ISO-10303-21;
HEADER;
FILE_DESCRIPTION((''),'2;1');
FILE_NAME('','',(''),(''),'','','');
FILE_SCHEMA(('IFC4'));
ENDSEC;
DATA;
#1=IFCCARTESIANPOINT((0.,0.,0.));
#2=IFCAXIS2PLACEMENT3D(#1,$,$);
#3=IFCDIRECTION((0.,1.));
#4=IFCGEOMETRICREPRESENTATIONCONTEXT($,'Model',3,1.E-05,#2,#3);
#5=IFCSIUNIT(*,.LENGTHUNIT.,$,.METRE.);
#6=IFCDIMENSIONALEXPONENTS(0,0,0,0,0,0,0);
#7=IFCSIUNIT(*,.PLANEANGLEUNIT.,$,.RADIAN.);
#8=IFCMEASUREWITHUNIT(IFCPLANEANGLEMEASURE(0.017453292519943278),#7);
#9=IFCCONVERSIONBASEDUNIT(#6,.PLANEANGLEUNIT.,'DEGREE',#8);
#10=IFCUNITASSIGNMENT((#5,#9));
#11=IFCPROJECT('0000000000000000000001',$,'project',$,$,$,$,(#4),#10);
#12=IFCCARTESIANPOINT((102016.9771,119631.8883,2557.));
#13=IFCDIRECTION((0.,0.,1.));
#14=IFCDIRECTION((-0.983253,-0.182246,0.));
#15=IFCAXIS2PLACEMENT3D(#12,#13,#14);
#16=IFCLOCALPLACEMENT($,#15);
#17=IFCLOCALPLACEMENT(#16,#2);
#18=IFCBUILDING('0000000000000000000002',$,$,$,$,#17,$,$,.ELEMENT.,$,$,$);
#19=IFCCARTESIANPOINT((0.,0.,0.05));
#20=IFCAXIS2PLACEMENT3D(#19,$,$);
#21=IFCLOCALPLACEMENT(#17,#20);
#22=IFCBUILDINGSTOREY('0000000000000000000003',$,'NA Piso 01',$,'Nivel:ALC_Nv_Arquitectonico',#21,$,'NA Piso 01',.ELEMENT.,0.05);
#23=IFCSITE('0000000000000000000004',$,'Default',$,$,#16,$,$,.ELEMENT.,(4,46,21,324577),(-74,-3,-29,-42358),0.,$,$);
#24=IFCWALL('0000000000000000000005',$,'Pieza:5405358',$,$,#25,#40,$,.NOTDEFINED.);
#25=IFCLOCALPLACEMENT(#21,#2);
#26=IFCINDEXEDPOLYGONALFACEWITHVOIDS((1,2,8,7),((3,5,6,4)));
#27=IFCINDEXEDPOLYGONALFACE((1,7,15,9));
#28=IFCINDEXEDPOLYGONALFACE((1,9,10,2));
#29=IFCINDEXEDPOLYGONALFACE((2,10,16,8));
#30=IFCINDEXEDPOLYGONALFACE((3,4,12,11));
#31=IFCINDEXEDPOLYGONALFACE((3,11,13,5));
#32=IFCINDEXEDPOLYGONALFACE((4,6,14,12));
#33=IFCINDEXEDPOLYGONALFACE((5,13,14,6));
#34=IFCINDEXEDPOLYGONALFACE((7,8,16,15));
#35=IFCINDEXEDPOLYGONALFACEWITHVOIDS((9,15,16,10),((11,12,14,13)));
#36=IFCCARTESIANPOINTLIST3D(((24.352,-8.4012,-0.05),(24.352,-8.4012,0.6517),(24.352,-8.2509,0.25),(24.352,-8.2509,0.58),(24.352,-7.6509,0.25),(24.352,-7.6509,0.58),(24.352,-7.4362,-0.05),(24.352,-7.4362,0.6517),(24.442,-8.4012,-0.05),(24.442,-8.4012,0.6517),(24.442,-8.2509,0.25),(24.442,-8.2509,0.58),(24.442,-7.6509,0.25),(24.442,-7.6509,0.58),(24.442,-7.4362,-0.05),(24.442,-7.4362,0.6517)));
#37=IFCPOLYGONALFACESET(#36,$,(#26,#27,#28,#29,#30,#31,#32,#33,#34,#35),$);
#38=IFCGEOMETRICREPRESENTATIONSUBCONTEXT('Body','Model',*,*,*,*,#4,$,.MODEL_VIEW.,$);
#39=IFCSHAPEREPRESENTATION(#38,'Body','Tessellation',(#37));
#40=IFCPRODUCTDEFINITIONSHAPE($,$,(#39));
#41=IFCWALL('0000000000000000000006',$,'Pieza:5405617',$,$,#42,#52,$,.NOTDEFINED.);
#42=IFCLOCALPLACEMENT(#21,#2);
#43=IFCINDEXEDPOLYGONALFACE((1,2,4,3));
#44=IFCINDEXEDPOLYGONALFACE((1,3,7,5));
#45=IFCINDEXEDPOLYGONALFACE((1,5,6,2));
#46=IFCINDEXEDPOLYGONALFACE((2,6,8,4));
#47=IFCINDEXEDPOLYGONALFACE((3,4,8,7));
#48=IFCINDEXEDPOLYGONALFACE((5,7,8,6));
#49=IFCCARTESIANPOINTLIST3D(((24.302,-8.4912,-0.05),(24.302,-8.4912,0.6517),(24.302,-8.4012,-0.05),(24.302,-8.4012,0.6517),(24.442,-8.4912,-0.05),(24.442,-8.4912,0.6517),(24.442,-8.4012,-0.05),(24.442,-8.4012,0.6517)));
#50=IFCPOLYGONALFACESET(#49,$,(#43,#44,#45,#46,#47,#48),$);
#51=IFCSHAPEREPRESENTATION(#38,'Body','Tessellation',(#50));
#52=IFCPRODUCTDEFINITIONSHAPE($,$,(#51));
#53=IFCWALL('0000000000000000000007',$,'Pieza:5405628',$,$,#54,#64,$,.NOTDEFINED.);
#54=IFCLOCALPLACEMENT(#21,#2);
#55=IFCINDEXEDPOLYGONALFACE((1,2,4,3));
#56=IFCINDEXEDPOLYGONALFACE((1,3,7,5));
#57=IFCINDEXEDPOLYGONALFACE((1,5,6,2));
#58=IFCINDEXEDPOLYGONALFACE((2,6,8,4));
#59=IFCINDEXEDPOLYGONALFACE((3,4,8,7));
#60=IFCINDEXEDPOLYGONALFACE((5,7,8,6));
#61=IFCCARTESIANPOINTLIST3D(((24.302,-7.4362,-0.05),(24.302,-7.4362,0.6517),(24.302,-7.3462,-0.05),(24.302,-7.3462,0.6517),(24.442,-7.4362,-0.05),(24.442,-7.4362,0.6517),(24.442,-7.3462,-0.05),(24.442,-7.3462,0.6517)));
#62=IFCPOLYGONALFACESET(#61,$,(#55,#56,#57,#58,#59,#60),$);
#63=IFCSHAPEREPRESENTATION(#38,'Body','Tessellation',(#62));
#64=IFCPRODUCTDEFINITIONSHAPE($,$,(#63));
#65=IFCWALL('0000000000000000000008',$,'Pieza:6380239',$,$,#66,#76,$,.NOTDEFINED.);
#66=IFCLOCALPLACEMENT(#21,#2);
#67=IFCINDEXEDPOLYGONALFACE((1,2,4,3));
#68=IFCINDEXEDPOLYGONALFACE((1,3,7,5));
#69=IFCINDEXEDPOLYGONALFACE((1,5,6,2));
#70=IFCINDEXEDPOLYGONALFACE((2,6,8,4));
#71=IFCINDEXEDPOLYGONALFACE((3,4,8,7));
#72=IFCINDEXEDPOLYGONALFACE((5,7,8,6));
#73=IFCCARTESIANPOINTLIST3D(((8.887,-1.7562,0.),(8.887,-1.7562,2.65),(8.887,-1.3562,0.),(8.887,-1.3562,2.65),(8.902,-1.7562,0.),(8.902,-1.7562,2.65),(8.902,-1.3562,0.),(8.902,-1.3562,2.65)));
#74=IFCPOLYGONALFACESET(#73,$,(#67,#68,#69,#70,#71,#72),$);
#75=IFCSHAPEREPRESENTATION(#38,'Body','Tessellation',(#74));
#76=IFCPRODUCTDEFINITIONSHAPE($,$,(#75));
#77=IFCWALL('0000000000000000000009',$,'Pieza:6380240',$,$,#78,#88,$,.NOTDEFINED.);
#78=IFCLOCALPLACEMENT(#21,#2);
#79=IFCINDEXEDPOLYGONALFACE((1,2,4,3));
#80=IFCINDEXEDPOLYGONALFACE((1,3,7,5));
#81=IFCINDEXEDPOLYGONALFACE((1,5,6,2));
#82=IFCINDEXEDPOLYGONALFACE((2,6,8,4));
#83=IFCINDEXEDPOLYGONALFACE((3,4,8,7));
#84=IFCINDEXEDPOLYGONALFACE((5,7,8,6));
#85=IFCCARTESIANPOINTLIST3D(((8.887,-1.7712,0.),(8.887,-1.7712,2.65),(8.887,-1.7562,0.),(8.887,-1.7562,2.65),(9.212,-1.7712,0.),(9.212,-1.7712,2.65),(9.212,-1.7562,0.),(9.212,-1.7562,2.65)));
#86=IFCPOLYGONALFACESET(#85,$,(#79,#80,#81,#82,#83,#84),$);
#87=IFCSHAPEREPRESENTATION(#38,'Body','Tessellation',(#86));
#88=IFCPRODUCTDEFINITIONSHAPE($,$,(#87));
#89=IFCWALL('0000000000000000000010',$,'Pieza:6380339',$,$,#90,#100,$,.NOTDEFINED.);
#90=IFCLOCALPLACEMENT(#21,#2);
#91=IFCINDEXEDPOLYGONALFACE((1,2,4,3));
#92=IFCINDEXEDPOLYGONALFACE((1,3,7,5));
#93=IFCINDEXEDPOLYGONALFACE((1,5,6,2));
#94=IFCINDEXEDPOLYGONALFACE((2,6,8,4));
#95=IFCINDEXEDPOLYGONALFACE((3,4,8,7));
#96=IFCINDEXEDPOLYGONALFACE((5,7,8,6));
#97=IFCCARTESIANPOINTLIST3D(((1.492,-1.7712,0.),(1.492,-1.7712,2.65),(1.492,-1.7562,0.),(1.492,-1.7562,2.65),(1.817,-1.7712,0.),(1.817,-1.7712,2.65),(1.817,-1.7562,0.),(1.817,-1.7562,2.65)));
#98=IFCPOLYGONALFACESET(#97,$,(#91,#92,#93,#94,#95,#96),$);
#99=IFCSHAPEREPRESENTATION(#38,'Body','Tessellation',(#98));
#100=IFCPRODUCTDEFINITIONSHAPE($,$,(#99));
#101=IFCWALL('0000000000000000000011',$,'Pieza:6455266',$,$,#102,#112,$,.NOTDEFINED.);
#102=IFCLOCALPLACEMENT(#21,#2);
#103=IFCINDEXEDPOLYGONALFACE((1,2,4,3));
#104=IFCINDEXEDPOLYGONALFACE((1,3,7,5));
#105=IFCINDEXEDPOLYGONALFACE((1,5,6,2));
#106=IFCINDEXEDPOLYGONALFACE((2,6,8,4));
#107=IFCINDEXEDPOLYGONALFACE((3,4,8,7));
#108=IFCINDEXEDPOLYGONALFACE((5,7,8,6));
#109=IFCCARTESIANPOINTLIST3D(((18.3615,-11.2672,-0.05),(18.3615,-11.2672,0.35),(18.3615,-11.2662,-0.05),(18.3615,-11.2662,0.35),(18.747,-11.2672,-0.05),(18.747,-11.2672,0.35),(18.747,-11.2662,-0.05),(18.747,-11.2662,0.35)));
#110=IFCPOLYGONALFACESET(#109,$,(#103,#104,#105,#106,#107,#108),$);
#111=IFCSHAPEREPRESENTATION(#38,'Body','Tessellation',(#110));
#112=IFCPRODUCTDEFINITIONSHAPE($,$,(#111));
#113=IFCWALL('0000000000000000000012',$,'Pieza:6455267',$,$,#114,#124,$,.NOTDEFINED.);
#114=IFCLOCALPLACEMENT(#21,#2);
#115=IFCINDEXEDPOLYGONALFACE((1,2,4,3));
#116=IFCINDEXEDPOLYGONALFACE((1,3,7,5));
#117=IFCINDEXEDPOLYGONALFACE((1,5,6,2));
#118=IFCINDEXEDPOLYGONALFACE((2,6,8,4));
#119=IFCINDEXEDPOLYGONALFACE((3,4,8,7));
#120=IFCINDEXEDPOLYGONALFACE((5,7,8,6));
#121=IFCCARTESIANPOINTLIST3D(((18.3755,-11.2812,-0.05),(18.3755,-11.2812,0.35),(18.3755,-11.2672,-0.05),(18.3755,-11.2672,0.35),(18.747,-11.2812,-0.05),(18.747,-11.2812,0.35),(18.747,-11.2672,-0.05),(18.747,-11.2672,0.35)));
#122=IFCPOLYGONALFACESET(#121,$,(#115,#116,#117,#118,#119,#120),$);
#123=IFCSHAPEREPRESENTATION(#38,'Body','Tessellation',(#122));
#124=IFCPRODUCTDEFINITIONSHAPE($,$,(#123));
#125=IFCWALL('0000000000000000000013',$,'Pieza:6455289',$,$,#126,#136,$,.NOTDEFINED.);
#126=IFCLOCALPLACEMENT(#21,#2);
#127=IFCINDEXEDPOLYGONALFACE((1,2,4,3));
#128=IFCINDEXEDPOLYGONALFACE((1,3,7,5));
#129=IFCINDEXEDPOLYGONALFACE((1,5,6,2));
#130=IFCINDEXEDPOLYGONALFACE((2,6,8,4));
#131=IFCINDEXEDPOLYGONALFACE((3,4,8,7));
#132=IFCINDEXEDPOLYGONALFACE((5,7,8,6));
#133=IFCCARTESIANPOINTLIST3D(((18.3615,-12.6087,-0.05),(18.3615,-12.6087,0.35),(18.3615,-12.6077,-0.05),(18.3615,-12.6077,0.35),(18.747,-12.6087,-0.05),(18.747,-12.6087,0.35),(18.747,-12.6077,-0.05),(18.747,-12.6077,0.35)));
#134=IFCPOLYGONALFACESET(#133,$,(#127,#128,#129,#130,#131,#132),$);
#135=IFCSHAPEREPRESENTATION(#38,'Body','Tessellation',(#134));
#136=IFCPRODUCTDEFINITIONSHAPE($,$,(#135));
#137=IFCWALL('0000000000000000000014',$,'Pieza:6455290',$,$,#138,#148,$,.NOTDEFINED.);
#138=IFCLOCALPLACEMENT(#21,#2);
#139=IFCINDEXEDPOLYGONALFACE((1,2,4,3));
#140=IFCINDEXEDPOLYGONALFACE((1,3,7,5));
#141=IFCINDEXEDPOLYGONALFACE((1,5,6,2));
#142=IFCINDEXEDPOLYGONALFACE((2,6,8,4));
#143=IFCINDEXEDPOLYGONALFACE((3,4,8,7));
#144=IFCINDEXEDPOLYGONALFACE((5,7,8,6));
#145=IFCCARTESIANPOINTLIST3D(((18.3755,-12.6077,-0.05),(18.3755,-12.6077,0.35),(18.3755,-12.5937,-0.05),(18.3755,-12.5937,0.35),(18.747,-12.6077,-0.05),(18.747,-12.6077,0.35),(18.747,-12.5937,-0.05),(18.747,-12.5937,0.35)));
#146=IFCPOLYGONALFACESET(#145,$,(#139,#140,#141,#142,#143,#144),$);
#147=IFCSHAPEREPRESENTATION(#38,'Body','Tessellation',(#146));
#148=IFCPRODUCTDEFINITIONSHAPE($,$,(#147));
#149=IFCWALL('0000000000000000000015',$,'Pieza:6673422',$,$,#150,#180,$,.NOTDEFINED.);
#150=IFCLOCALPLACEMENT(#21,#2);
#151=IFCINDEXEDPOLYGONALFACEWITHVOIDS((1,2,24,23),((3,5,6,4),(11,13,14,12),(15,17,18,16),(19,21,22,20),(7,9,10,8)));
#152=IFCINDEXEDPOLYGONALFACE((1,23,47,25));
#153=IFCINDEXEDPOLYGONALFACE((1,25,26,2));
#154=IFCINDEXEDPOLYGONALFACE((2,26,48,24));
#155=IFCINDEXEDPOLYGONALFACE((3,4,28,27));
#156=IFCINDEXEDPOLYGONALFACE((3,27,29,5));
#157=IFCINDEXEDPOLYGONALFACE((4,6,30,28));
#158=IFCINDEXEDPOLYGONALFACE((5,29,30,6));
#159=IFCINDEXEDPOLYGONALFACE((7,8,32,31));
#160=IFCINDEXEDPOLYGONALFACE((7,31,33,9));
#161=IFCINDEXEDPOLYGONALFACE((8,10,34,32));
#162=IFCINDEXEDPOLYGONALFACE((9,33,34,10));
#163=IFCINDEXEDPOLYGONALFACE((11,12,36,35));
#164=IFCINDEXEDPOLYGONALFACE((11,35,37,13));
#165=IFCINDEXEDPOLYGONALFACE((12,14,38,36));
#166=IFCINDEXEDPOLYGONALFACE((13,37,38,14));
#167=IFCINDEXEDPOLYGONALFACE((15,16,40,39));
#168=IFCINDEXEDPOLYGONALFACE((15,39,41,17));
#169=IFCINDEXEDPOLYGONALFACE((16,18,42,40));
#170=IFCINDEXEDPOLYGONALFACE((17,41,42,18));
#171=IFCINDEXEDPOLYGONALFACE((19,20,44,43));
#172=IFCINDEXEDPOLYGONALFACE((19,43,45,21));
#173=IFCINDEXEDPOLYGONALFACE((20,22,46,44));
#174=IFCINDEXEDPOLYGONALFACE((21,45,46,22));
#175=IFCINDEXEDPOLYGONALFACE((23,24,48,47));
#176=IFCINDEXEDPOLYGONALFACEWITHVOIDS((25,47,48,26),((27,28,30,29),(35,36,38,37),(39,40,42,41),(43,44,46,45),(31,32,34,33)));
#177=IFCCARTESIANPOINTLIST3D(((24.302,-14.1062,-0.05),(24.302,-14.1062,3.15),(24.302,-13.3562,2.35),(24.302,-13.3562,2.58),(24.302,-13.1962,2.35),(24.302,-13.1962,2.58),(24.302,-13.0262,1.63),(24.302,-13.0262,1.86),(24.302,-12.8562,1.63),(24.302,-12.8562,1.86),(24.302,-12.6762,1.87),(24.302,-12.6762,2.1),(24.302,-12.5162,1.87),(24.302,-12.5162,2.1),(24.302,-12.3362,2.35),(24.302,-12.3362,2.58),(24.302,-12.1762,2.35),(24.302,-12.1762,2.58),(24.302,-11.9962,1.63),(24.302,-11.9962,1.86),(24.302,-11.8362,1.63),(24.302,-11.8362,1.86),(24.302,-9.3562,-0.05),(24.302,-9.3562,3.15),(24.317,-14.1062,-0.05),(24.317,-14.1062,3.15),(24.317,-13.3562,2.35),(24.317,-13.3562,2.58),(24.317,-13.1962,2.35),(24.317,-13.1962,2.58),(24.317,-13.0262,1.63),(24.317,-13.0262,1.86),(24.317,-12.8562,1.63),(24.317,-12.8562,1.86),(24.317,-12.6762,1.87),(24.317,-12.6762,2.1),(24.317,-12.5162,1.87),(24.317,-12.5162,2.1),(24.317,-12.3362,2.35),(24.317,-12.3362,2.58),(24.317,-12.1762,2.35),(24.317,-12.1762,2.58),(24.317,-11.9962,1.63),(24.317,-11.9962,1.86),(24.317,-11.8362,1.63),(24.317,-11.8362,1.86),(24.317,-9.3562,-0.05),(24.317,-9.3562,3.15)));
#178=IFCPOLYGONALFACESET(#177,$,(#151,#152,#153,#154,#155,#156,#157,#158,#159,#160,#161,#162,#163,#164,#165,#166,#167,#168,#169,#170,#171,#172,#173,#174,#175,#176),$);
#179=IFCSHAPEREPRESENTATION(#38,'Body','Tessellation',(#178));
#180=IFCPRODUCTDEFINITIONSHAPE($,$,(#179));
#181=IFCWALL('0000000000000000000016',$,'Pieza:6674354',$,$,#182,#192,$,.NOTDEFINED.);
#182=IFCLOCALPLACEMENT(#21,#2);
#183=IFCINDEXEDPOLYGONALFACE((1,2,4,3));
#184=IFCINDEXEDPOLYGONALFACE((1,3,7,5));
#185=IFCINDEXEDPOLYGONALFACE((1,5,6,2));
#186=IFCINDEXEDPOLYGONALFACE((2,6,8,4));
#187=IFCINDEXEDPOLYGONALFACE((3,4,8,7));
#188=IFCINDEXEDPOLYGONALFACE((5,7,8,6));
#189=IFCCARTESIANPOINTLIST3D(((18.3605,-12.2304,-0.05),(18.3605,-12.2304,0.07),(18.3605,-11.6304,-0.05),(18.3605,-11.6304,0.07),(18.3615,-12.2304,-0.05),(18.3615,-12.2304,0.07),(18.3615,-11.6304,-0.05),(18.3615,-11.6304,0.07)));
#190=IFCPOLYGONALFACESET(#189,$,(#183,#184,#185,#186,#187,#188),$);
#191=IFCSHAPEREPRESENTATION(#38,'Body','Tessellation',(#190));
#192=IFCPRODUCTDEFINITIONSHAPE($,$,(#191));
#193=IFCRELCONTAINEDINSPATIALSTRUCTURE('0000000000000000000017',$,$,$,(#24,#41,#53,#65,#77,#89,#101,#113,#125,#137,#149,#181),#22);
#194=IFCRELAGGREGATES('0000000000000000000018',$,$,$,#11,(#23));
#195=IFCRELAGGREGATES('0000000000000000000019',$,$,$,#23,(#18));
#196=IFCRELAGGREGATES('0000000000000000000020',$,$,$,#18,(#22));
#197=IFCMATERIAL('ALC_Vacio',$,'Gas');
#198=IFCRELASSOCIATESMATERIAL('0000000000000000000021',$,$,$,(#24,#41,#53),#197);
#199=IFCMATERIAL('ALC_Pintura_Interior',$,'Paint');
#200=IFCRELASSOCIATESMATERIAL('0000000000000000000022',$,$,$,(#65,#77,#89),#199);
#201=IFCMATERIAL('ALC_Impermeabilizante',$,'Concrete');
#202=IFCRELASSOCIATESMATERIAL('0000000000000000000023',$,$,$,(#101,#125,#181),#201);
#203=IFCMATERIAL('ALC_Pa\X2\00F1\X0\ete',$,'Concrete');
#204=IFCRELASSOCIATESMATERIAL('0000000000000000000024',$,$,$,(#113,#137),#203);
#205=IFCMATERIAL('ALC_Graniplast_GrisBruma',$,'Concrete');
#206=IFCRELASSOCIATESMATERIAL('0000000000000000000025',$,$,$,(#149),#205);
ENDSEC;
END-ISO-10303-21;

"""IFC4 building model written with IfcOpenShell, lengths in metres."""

from ifc_helpers import new_model, entity, si_unit, converted_unit, direction, frame, frame_2d, origin, origin_2d_with_axis, place, context, subcontext, project, spatial, rectangle, extrude, boolean, material, element, save


model = new_model("IFC4")

# Units and contexts
model_context = context("Model", 3, precision=1e-05, world=origin(), true_north=direction((0.0, 1.0)))
body_context = subcontext(model_context, "Body", "Model", "MODEL_VIEW")
ifc_project = project(units=[si_unit("LENGTHUNIT", "METRE"), converted_unit("PLANEANGLEUNIT", "DEGREE", entity("IfcPlaneAngleMeasure", 0.017453292519943278), si_unit("PLANEANGLEUNIT", "RADIAN"), dimensions=[0, 0, 0, 0, 0, 0, 0])], contexts=[model_context])

# Site, building, storey
site_placement = place(None, frame((102016.9771, 119631.8883, 2557.0), z_axis=(0.0, 0.0, 1.0), x_axis=(-0.983253, -0.182246, 0.0)))
site = spatial("IfcSite", under=ifc_project, at=site_placement, Name="Default", CompositionType="ELEMENT", RefLatitude=(4, 46, 21, 324577), RefLongitude=(-74, -3, -29, -42358), RefElevation=0.0)
building_placement = place(site_placement, origin())
building = spatial("IfcBuilding", under=site, at=building_placement, CompositionType="ELEMENT")
storey_placement = place(building_placement, frame((0.0, 0.0, 0.05)))
storey = spatial("IfcBuildingStorey", under=building, at=storey_placement, Name="NA Piso 01", ObjectType="Nivel:ALC_Nv_Arquitectonico", LongName="NA Piso 01", CompositionType="ELEMENT", Elevation=0.05)

# Walls
ifc_material_1 = material(Name="ALC_Vacio", Category="Gas")
wall_1_placement = place(storey_placement, frame((0.0, 0.0, -0.05)))
element("IfcWall", 1, at=wall_1_placement, inside=storey, material=ifc_material_1, Name="Pieza:5405358", PredefinedType="NOTDEFINED", context=body_context, shape_type="SweptSolid", body=[
    boolean("DIFFERENCE", extrude(rectangle(XDim=0.09, YDim=0.965, at=frame_2d((0.0, 0.0), x_axis=(1.0, 0.0))), frame((24.397, -7.9187, 0.0)), (0.0, 0.0, 1.0), 0.7017), extrude(rectangle(XDim=0.33, YDim=0.6, at=frame_2d((0.0, 0.0), x_axis=(0.0, 1.0))), frame((24.352, -7.9509, 0.465), z_axis=(1.0, 0.0, 0.0), x_axis=(0.0, -1.0, 0.0)), (0.0, 0.0, 1.0), 0.09)),
])
wall_2_placement = place(storey_placement, frame((0.0, 0.0, -0.05)))
element("IfcWall", 2, at=wall_2_placement, inside=storey, material=ifc_material_1, Name="Pieza:5405617", PredefinedType="NOTDEFINED", context=body_context, shape_type="SweptSolid", body=[
    extrude(rectangle(XDim=0.09, YDim=0.14, at=frame_2d((0.0, 0.0), x_axis=(1.0, 0.0))), frame((24.372, -8.4462, 0.0), z_axis=(0.0, 0.0, 1.0), x_axis=(0.0, -1.0, 0.0)), (0.0, 0.0, 1.0), 0.7017),
])
wall_3_placement = place(storey_placement, frame((0.0, 0.0, -0.05)))
element("IfcWall", 3, at=wall_3_placement, inside=storey, material=ifc_material_1, Name="Pieza:5405628", PredefinedType="NOTDEFINED", context=body_context, shape_type="SweptSolid", body=[
    extrude(rectangle(XDim=0.09, YDim=0.14, at=frame_2d((0.0, 0.0), x_axis=(1.0, 0.0))), frame((24.372, -7.3912, 0.0), z_axis=(0.0, 0.0, 1.0), x_axis=(0.0, -1.0, 0.0)), (0.0, 0.0, 1.0), 0.7017),
])
ifc_material_2 = material(Name="ALC_Graniplast_GrisBruma", Category="Concrete")
ifc_material_3 = material(Name="ALC_Pintura_Interior", Category="Paint")
wall_4_placement = place(storey_placement, origin())
element("IfcWall", 4, at=wall_4_placement, inside=storey, material=ifc_material_3, Name="Pieza:6380239", PredefinedType="NOTDEFINED", context=body_context, shape_type="SweptSolid", body=[
    extrude(rectangle(XDim=0.4, YDim=0.015, at=frame_2d((0.0, 0.0), x_axis=(1.0, 0.0))), frame((8.8945, -1.5562, 0.0), z_axis=(0.0, 0.0, 1.0), x_axis=(0.0, -1.0, 0.0)), (0.0, 0.0, 1.0), 2.65),
])
wall_5_placement = place(storey_placement, origin())
element("IfcWall", 5, at=wall_5_placement, inside=storey, material=ifc_material_3, Name="Pieza:6380240", PredefinedType="NOTDEFINED", context=body_context, shape_type="SweptSolid", body=[
    extrude(rectangle(XDim=0.015, YDim=0.325, at=frame_2d((0.0, 0.0), x_axis=(1.0, 0.0))), frame((9.0495, -1.7637, 0.0), z_axis=(0.0, 0.0, 1.0), x_axis=(0.0, -1.0, 0.0)), (0.0, 0.0, 1.0), 2.65),
])
wall_6_placement = place(storey_placement, origin())
element("IfcWall", 6, at=wall_6_placement, inside=storey, material=ifc_material_3, Name="Pieza:6380339", PredefinedType="NOTDEFINED", context=body_context, shape_type="SweptSolid", body=[
    extrude(rectangle(XDim=0.015, YDim=0.325, at=frame_2d((0.0, 0.0), x_axis=(1.0, 0.0))), frame((1.6545, -1.7637, 0.0), z_axis=(0.0, 0.0, 1.0), x_axis=(0.0, -1.0, 0.0)), (0.0, 0.0, 1.0), 2.65),
])
ifc_material_4 = material(Name="ALC_Impermeabilizante", Category="Concrete")
wall_7_placement = place(storey_placement, frame((0.0, 0.0, -0.05)))
element("IfcWall", 7, at=wall_7_placement, inside=storey, material=ifc_material_4, Name="Pieza:6455266", PredefinedType="NOTDEFINED", context=body_context, shape_type="SweptSolid", body=[
    extrude(rectangle(XDim=0.001, YDim=0.3855, at=frame_2d((0.0, 0.0), x_axis=(1.0, 0.0))), frame((18.5543, -11.2667, 0.0), z_axis=(0.0, 0.0, 1.0), x_axis=(0.0, -1.0, 0.0)), (0.0, 0.0, 1.0), 0.4),
])
ifc_material_5 = material(Name="ALC_Pañete", Category="Concrete")
wall_8_placement = place(storey_placement, frame((0.0, 0.0, -0.05)))
element("IfcWall", 8, at=wall_8_placement, inside=storey, material=ifc_material_5, Name="Pieza:6455267", PredefinedType="NOTDEFINED", context=body_context, shape_type="SweptSolid", body=[
    extrude(rectangle(XDim=0.014, YDim=0.3715, at=frame_2d((0.0, 0.0), x_axis=(1.0, 0.0))), frame((18.5613, -11.2742, 0.0), z_axis=(0.0, 0.0, 1.0), x_axis=(0.0, -1.0, 0.0)), (0.0, 0.0, 1.0), 0.4),
])
wall_9_placement = place(storey_placement, frame((0.0, 0.0, -0.05)))
element("IfcWall", 9, at=wall_9_placement, inside=storey, material=ifc_material_4, Name="Pieza:6455289", PredefinedType="NOTDEFINED", context=body_context, shape_type="SweptSolid", body=[
    extrude(rectangle(XDim=0.001, YDim=0.3855, at=origin_2d_with_axis()), frame((18.5543, -12.6082, 0.0), z_axis=(0.0, 0.0, 1.0), x_axis=(0.0, -1.0, 0.0)), (0.0, 0.0, 1.0), 0.4),
])
wall_10_placement = place(storey_placement, frame((0.0, 0.0, -0.05)))
element("IfcWall", 10, at=wall_10_placement, inside=storey, material=ifc_material_5, Name="Pieza:6455290", PredefinedType="NOTDEFINED", context=body_context, shape_type="SweptSolid", body=[
    extrude(rectangle(XDim=0.014, YDim=0.3715, at=frame_2d((0.0, 0.0), x_axis=(1.0, 0.0))), frame((18.5613, -12.6007, 0.0), z_axis=(0.0, 0.0, 1.0), x_axis=(0.0, -1.0, 0.0)), (0.0, 0.0, 1.0), 0.4),
])
wall_11_placement = place(storey_placement, frame((0.0, 0.0, -0.05)))
element("IfcWall", 11, at=wall_11_placement, inside=storey, material=ifc_material_2, Name="Pieza:6673422", PredefinedType="NOTDEFINED", context=body_context, shape_type="SweptSolid", body=[
    boolean("DIFFERENCE", boolean("DIFFERENCE", boolean("DIFFERENCE", boolean("DIFFERENCE", boolean("DIFFERENCE", extrude(rectangle(XDim=0.015, YDim=4.75, at=frame_2d((0.0, 0.0), x_axis=(1.0, 0.0))), frame((24.3095, -11.7312, 0.0)), (0.0, 0.0, 1.0), 3.2), extrude(rectangle(XDim=0.23, YDim=0.17, at=frame_2d((0.0, 0.0), x_axis=(0.0, 1.0))), frame((24.302, -12.9412, 1.795), z_axis=(1.0, 0.0, 0.0), x_axis=(0.0, -1.0, 0.0)), (0.0, 0.0, 1.0), 0.015)), extrude(rectangle(XDim=0.23, YDim=0.16, at=frame_2d((0.0, 0.0), x_axis=(0.0, 1.0))), frame((24.302, -11.9162, 1.795), z_axis=(1.0, 0.0, 0.0), x_axis=(0.0, -1.0, 0.0)), (0.0, 0.0, 1.0), 0.015)), extrude(rectangle(XDim=0.23, YDim=0.16, at=frame_2d((0.0, 0.0), x_axis=(0.0, 1.0))), frame((24.302, -12.5962, 2.035), z_axis=(1.0, 0.0, 0.0), x_axis=(0.0, -1.0, 0.0)), (0.0, 0.0, 1.0), 0.015)), extrude(rectangle(XDim=0.23, YDim=0.16, at=frame_2d((0.0, 0.0), x_axis=(0.0, 1.0))), frame((24.302, -13.2762, 2.515), z_axis=(1.0, 0.0, 0.0), x_axis=(0.0, -1.0, 0.0)), (0.0, 0.0, 1.0), 0.015)), extrude(rectangle(XDim=0.23, YDim=0.16, at=frame_2d((0.0, 0.0), x_axis=(0.0, 1.0))), frame((24.302, -12.2562, 2.515), z_axis=(1.0, 0.0, 0.0), x_axis=(0.0, -1.0, 0.0)), (0.0, 0.0, 1.0), 0.015)),
])
wall_12_placement = place(storey_placement, frame((0.0, 0.0, -0.05)))
element("IfcWall", 12, at=wall_12_placement, inside=storey, material=ifc_material_4, Name="Pieza:6674354", PredefinedType="NOTDEFINED", context=body_context, shape_type="SweptSolid", body=[
    extrude(rectangle(XDim=0.6, YDim=0.001, at=frame_2d((0.0, 0.0), x_axis=(1.0, 0.0))), frame((18.361, -11.9304, 0.0), z_axis=(0.0, 0.0, 1.0), x_axis=(0.0, -1.0, 0.0)), (0.0, 0.0, 1.0), 0.12),
])

save(model, "model.ifc")
